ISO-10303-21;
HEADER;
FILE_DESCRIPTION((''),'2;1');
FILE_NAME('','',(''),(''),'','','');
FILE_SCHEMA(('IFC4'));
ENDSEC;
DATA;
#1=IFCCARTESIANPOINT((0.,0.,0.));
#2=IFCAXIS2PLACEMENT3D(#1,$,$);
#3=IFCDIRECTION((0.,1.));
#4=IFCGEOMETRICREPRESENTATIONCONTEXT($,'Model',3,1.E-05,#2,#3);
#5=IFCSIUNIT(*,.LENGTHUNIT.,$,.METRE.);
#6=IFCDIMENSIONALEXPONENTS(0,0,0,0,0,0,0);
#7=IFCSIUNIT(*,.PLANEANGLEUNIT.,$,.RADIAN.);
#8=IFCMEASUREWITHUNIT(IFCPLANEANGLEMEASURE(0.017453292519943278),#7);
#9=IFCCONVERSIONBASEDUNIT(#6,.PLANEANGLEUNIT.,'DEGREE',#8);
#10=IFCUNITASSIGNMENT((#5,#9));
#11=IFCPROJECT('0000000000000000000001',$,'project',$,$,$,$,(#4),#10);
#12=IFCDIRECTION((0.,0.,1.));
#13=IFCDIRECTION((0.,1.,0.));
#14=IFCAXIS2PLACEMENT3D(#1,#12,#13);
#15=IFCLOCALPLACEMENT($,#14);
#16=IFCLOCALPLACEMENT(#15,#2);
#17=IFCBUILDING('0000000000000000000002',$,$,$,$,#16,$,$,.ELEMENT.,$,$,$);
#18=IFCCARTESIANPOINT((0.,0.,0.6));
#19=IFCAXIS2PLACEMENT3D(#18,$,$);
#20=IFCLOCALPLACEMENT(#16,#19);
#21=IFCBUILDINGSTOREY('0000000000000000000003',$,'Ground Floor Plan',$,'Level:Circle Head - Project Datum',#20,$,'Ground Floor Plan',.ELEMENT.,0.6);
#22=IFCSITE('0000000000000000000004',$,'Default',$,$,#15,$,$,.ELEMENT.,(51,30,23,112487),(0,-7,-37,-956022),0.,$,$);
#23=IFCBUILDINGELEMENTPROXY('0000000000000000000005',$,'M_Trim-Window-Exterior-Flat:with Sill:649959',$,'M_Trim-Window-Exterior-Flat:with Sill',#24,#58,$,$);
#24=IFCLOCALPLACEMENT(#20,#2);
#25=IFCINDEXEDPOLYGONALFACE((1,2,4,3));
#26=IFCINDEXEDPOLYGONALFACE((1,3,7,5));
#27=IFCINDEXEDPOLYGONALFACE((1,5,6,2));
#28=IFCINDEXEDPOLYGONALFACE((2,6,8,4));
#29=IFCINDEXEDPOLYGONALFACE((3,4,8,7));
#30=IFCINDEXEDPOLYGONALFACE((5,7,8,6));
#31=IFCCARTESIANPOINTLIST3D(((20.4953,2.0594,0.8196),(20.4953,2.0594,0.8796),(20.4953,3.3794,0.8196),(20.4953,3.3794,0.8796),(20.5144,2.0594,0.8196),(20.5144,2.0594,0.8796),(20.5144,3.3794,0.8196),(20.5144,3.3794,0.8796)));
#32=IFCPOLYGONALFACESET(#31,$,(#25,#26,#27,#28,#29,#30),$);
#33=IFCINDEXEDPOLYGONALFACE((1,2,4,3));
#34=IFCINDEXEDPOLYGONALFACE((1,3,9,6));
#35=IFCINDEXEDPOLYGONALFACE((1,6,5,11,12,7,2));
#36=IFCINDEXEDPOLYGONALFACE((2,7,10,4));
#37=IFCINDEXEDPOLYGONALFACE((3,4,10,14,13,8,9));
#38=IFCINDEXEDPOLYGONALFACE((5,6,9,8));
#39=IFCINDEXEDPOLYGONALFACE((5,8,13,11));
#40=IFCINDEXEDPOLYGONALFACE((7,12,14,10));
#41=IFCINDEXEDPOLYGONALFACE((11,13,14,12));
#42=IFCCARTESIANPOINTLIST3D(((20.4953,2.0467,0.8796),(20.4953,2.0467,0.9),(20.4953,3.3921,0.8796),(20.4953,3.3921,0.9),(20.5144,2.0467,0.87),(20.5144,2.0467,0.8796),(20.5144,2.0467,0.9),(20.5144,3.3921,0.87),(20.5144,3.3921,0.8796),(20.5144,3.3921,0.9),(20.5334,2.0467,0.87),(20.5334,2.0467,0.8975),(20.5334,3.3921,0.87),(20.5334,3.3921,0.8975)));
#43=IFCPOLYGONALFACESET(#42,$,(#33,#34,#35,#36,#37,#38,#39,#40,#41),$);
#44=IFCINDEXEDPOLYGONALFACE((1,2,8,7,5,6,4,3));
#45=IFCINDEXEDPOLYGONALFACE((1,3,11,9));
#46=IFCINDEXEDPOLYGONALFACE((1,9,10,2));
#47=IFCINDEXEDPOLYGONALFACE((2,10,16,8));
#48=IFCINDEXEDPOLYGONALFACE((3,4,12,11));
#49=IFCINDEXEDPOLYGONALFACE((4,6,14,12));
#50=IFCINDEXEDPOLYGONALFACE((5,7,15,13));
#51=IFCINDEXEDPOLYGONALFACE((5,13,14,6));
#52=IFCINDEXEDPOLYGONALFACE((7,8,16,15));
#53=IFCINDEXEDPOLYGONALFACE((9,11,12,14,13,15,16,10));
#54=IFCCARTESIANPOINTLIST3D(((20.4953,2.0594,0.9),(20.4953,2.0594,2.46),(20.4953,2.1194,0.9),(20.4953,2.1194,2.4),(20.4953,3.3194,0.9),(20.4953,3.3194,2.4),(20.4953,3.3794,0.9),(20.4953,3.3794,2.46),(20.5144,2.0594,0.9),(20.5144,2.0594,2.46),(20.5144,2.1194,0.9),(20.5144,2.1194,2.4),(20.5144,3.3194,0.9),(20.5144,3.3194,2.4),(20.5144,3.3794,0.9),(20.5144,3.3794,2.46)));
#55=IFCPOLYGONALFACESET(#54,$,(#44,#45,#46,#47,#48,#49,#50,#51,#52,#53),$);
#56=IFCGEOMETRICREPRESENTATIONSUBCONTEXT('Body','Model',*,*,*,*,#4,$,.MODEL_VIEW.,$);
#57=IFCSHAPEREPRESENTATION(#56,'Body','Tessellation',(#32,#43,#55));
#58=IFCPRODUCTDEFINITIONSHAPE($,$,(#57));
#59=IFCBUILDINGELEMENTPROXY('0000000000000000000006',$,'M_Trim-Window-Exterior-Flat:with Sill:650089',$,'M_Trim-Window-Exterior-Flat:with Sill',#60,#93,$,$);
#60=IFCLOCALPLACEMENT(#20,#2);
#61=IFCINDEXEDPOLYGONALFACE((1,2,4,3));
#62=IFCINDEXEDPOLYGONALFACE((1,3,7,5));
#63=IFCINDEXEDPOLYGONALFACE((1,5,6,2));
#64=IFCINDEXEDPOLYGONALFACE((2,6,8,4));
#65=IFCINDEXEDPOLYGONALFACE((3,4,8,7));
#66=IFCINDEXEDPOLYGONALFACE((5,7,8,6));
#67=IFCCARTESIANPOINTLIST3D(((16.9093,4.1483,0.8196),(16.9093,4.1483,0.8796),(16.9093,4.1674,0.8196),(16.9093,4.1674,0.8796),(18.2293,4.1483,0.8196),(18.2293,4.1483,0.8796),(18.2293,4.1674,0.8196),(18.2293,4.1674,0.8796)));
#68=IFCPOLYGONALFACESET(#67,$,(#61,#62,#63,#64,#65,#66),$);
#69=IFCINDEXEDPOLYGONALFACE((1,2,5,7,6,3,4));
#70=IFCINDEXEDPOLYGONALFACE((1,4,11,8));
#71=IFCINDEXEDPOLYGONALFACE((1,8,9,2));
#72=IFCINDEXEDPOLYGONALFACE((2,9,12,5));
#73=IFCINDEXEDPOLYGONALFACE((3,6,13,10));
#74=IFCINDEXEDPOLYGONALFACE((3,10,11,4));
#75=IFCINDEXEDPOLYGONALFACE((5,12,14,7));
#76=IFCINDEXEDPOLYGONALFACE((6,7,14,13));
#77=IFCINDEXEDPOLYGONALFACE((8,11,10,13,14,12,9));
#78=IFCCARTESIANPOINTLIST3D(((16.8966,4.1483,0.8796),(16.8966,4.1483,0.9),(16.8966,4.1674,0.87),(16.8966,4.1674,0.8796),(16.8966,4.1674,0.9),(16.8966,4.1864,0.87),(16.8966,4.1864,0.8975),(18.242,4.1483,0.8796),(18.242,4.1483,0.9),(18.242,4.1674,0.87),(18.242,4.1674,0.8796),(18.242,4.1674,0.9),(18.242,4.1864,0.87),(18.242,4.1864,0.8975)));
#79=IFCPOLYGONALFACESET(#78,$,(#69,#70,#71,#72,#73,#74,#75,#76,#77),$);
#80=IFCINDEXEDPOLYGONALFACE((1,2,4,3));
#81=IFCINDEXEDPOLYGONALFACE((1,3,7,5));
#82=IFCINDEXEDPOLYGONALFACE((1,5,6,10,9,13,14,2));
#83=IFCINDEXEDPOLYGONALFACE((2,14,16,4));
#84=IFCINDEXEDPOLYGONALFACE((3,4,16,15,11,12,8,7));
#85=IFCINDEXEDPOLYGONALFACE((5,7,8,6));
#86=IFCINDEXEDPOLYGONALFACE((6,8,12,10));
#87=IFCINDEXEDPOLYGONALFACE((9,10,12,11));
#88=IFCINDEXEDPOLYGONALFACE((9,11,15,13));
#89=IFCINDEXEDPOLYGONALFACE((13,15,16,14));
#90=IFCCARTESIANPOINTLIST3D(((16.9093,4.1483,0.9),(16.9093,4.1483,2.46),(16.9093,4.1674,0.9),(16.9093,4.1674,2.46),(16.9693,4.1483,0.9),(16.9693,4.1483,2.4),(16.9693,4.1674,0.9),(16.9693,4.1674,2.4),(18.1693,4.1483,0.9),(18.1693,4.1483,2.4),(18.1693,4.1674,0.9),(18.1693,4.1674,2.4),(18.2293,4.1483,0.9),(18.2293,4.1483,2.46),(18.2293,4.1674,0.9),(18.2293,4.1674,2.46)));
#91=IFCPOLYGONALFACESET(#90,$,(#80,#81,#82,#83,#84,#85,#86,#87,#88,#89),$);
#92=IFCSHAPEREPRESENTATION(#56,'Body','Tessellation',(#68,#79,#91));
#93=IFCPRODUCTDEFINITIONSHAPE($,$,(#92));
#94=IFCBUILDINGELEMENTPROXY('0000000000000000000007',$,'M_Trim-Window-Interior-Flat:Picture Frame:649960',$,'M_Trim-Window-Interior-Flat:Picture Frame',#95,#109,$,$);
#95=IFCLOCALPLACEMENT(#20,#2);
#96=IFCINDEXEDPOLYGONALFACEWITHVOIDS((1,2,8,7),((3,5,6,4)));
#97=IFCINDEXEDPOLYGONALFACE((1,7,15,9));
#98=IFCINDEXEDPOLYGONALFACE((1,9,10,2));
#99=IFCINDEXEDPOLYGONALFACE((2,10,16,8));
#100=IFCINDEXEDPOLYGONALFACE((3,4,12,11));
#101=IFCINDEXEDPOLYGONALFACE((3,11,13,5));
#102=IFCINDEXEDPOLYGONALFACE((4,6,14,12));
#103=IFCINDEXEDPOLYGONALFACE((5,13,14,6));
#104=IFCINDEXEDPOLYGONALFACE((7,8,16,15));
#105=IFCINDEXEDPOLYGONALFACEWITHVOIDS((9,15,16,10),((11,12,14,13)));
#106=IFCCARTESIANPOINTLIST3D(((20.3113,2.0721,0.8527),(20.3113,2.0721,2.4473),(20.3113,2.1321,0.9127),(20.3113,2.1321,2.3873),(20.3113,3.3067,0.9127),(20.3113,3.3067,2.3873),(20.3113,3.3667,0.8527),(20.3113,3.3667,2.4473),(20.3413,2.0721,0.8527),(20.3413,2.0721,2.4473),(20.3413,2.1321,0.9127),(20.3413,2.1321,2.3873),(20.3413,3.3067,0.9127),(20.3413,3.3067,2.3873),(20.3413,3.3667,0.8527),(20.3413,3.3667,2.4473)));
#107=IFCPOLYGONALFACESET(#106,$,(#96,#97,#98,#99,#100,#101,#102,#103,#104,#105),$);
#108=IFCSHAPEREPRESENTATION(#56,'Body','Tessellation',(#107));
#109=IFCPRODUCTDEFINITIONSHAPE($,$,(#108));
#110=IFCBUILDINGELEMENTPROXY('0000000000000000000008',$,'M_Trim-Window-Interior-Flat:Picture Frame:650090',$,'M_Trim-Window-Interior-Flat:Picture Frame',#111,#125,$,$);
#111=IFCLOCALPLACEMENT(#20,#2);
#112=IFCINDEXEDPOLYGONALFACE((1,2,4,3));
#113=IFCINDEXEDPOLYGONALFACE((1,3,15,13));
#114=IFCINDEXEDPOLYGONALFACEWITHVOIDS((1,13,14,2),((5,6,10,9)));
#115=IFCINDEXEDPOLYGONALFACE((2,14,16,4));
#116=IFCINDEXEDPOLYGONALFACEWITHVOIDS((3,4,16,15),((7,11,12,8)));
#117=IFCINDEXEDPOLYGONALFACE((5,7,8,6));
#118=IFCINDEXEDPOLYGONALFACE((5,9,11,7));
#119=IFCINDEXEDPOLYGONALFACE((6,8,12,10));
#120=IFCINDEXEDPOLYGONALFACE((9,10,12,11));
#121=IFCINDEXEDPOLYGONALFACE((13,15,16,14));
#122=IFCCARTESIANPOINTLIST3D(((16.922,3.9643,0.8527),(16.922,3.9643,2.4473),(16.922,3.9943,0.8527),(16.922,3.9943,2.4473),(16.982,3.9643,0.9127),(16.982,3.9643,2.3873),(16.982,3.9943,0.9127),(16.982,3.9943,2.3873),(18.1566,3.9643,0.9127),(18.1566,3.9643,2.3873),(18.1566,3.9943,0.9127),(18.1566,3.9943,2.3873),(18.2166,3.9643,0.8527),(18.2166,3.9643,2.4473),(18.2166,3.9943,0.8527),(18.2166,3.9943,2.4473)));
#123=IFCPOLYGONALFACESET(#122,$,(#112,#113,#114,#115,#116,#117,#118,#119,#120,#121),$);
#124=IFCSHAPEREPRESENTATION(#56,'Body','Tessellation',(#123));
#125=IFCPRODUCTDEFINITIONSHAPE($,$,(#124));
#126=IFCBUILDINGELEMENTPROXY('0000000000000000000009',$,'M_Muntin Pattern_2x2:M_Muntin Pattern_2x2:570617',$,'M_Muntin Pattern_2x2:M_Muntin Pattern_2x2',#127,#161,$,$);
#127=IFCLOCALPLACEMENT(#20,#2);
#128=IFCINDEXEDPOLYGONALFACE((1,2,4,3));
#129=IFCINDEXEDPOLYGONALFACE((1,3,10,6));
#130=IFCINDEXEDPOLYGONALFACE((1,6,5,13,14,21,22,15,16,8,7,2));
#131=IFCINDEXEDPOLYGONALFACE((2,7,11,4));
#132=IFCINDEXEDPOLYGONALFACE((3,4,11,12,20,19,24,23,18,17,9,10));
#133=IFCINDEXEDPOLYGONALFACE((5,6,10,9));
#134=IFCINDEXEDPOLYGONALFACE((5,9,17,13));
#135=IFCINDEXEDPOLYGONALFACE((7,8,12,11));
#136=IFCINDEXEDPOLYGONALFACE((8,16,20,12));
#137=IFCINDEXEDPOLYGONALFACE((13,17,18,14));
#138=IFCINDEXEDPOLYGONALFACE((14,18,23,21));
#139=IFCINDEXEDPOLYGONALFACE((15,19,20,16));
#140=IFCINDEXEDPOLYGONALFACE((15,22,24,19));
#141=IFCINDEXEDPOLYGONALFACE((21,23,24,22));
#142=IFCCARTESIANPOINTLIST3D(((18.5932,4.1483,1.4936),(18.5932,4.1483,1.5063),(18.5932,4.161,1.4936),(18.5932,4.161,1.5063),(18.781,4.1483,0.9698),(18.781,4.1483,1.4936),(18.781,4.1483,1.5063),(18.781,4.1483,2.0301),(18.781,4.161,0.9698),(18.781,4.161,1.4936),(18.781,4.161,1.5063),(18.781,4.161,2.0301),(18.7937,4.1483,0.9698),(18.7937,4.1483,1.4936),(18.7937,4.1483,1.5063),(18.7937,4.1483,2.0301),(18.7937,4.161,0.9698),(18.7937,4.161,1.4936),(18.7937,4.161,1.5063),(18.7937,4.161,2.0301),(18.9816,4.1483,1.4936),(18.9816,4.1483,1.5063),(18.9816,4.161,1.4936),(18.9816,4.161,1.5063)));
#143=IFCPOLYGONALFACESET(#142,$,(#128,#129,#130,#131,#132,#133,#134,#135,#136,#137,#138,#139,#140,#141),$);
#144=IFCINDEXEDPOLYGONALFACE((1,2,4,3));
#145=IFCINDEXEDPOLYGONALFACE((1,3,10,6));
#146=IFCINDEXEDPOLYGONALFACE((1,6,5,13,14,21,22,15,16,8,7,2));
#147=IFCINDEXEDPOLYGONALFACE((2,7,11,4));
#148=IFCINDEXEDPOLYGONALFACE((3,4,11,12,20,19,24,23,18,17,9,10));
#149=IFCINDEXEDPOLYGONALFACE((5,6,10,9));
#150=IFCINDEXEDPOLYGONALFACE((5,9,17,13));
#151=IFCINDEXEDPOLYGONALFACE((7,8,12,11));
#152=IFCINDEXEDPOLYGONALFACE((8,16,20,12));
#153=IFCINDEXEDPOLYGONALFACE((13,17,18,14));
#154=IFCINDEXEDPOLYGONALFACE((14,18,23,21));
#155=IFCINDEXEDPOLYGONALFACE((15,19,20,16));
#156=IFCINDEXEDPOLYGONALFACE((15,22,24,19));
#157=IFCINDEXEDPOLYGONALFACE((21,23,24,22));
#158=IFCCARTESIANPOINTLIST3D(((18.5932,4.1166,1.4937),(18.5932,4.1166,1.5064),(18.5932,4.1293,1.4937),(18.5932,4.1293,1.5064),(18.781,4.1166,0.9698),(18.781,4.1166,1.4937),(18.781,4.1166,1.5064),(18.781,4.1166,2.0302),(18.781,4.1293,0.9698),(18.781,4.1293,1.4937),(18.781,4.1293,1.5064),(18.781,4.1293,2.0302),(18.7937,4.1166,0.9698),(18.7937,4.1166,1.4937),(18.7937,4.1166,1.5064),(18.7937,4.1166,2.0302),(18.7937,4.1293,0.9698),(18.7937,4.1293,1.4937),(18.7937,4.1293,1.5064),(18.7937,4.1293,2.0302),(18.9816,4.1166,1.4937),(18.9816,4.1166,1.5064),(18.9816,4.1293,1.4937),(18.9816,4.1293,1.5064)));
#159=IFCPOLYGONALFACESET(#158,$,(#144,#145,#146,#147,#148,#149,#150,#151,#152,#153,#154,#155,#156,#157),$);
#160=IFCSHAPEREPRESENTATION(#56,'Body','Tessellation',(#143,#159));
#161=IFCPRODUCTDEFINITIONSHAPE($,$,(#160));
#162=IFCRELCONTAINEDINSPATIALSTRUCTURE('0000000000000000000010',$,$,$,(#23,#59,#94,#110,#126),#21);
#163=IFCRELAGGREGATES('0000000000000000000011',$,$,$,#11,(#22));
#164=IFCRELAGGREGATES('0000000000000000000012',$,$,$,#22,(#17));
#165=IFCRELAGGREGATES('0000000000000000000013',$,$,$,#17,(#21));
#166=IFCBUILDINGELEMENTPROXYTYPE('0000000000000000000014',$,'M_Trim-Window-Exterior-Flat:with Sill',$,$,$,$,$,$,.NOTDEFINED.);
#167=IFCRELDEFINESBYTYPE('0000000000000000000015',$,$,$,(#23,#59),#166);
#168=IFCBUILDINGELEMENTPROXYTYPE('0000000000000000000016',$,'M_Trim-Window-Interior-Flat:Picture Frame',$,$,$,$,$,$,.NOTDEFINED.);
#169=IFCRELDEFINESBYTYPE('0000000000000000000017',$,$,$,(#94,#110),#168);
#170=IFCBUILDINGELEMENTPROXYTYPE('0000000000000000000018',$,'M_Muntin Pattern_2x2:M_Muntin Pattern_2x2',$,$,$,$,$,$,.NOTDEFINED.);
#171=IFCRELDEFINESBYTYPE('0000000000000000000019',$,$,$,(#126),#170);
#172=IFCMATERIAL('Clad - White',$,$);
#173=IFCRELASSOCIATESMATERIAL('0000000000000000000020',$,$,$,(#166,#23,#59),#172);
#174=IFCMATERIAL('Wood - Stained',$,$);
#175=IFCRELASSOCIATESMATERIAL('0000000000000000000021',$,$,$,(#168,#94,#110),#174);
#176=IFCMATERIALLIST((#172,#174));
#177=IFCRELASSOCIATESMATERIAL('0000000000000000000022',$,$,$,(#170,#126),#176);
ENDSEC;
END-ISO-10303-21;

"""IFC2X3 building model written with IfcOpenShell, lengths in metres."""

from ifc_helpers import new_model, entity, si_unit, converted_unit, direction, frame, frame_2d, origin, place, context, subcontext, project, spatial, polyline, rectangle, outline, extrude, source, transform, mapped, material, material_list, type_object, type_shapes, element, save


model = new_model("IFC2X3")

# Units and contexts
model_context = context("Model", 3, precision=1e-05, world=origin(), true_north=direction((0.0, 1.0)))
body_context = subcontext(model_context, "Body", "Model", "MODEL_VIEW")
ifc_project = project(units=[si_unit("LENGTHUNIT", "METRE"), converted_unit("PLANEANGLEUNIT", "DEGREE", entity("IfcPlaneAngleMeasure", 0.017453292519943278), si_unit("PLANEANGLEUNIT", "RADIAN"), dimensions=[0, 0, 0, 0, 0, 0, 0])], contexts=[model_context])

# Site, building, storey
site_placement = place(None, frame((0.0, 0.0, 0.0), z_axis=(0.0, 0.0, 1.0), x_axis=(0.0, 1.0, 0.0)))
site = spatial("IfcSite", under=ifc_project, at=site_placement, Name="Default", CompositionType="ELEMENT", RefLatitude=(51, 30, 23, 112487), RefLongitude=(0, -7, -37, -956022), RefElevation=0.0)
building_placement = place(site_placement, origin())
building = spatial("IfcBuilding", under=site, at=building_placement, CompositionType="ELEMENT")
storey_placement = place(building_placement, frame((0.0, 0.0, 0.6)))
storey = spatial("IfcBuildingStorey", under=building, at=storey_placement, Name="Ground Floor Plan", ObjectType="Level:Circle Head - Project Datum", LongName="Ground Floor Plan", CompositionType="ELEMENT", Elevation=0.6)

# Building element proxies
ifc_material_1 = material(Name="Clad - White")
ifc_material_2 = material(Name="Wood - Stained")
ifc_material_list = material_list([ifc_material_1, ifc_material_2])
building_element_proxy_type_1 = type_object("IfcBuildingElementProxyType", Name="M_Trim-Window-Exterior-Flat:with Sill", PredefinedType="NOTDEFINED", material=ifc_material_1)
shared_shape_1 = source(origin(), body_context, "Body", "SweptSolid", [
    extrude(rectangle(XDim=1.32, YDim=0.06, at=frame_2d((0.0, 0.0), x_axis=(1.0, 0.0))), frame((0.0, -1.5504, 0.0), z_axis=(0.0, 0.0, 1.0), x_axis=(-1.0, 0.0, 0.0)), (0.0, 0.0, 1.0), 0.019),
    extrude(outline(polyline([(-0.019, -0.0152), (0.0, -0.0152), (0.0, -0.0057), (0.019, -0.0057), (0.019, 0.0148), (0.0, 0.0148), (-0.019, 0.0123), (-0.019, -0.0152)])), frame((-0.6727, -1.5148, 0.019), z_axis=(1.0, 0.0, 0.0), x_axis=(0.0, 0.0, -1.0)), (0.0, 0.0, 1.0), 1.3454),
    extrude(outline(polyline([(-0.795, -0.66), (0.765, -0.66), (0.765, -0.6), (-0.735, -0.6), (-0.735, 0.6), (0.765, 0.6), (0.765, 0.66), (-0.795, 0.66), (-0.795, -0.66)])), frame((0.0, -0.735, 0.0), z_axis=(0.0, 0.0, 1.0), x_axis=(0.0, -1.0, 0.0)), (0.0, 0.0, 1.0), 0.019),
])
type_shapes(building_element_proxy_type_1, [shared_shape_1])
for number, where, z_axis, x_axis, name in (
    (1, (20.4953, 2.7194, 2.4), (1.0, 0.0, 0.0), (0.0, 1.0, 0.0), "M_Trim-Window-Exterior-Flat:with Sill:649959"),
    (2, (17.5693, 4.1483, 2.4), (0.0, 1.0, 0.0), (-1.0, 0.0, 0.0), "M_Trim-Window-Exterior-Flat:with Sill:650089"),
):
    element("IfcBuildingElementProxy", number, at=place(storey_placement, frame(where, z_axis=z_axis, x_axis=x_axis)), inside=storey, type_object=building_element_proxy_type_1, material=ifc_material_1, Name=name, ObjectType="M_Trim-Window-Exterior-Flat:with Sill", context=body_context, shape_type="MappedRepresentation", body=[
        mapped(shared_shape_1, transform((0.0, 0.0, 0.0), scale=1.0)),
    ])
building_element_proxy_type_2 = type_object("IfcBuildingElementProxyType", Name="M_Trim-Window-Interior-Flat:Picture Frame", PredefinedType="NOTDEFINED", material=ifc_material_2)
shared_shape_2 = source(origin(), body_context, "Body", "SweptSolid", [
    extrude(outline(polyline([(-0.6473, -0.7973), (0.6473, -0.7973), (0.6473, 0.7973), (-0.6473, 0.7973), (-0.6473, -0.7973)]), holes=[polyline([(-0.5873, -0.7373), (-0.5873, 0.7373), (0.5873, 0.7373), (0.5873, -0.7373), (-0.5873, -0.7373)])]), frame((0.0, -0.75, 0.0), z_axis=(0.0, 0.0, 1.0), x_axis=(-1.0, 0.0, 0.0)), (0.0, 0.0, 1.0), 0.03),
])
type_shapes(building_element_proxy_type_2, [shared_shape_2])
for number, where, z_axis, x_axis, name in (
    (3, (20.3413, 2.7194, 2.4), (-1.0, 0.0, 0.0), (0.0, -1.0, 0.0), "M_Trim-Window-Interior-Flat:Picture Frame:649960"),
    (4, (17.5693, 3.9943, 2.4), (0.0, -1.0, 0.0), (1.0, 0.0, 0.0), "M_Trim-Window-Interior-Flat:Picture Frame:650090"),
):
    element("IfcBuildingElementProxy", number, at=place(storey_placement, frame(where, z_axis=z_axis, x_axis=x_axis)), inside=storey, type_object=building_element_proxy_type_2, material=ifc_material_2, Name=name, ObjectType="M_Trim-Window-Interior-Flat:Picture Frame", context=body_context, shape_type="MappedRepresentation", body=[
        mapped(shared_shape_2, transform((0.0, 0.0, 0.0), scale=1.0)),
    ])
building_element_proxy_type_3 = type_object("IfcBuildingElementProxyType", Name="M_Muntin Pattern_2x2:M_Muntin Pattern_2x2", PredefinedType="NOTDEFINED", material=ifc_material_list)
shared_shape_3 = source(origin(), body_context, "Body", "SweptSolid", [
    extrude(outline(polyline([(0.0064, -0.0064), (0.5301, -0.0064), (0.5301, 0.0063), (0.0064, 0.0063), (0.0064, 0.1942), (-0.0063, 0.1942), (-0.0063, 0.0063), (-0.5302, 0.0063), (-0.5302, -0.0064), (-0.0063, -0.0064), (-0.0063, -0.1942), (0.0064, -0.1942), (0.0064, -0.0064)])), frame((0.0, 0.0095, 0.5301), z_axis=(0.0, 1.0, 0.0), x_axis=(0.0, 0.0, 1.0)), (0.0, 0.0, 1.0), 0.0127),
    extrude(outline(polyline([(0.0064, -0.0064), (0.5302, -0.0064), (0.5302, 0.0063), (0.0064, 0.0063), (0.0064, 0.1942), (-0.0063, 0.1942), (-0.0063, 0.0063), (-0.5302, 0.0063), (-0.5302, -0.0064), (-0.0063, -0.0064), (-0.0063, -0.1942), (0.0064, -0.1942), (0.0064, -0.0064)])), frame((0.0, -0.0222, 0.5302), z_axis=(0.0, 1.0, 0.0), x_axis=(0.0, 0.0, 1.0)), (0.0, 0.0, 1.0), 0.0127),
])
type_shapes(building_element_proxy_type_3, [shared_shape_3])
proxy_1_placement = place(storey_placement, frame((18.7874, 4.1388, 0.9698)))
element("IfcBuildingElementProxy", 5, at=proxy_1_placement, inside=storey, type_object=building_element_proxy_type_3, material=ifc_material_list, Name="M_Muntin Pattern_2x2:M_Muntin Pattern_2x2:570617", ObjectType="M_Muntin Pattern_2x2:M_Muntin Pattern_2x2", context=body_context, shape_type="MappedRepresentation", body=[
    mapped(shared_shape_3, transform((0.0, 0.0, 0.0), scale=1.0)),
])

save(model, "model.ifc")
